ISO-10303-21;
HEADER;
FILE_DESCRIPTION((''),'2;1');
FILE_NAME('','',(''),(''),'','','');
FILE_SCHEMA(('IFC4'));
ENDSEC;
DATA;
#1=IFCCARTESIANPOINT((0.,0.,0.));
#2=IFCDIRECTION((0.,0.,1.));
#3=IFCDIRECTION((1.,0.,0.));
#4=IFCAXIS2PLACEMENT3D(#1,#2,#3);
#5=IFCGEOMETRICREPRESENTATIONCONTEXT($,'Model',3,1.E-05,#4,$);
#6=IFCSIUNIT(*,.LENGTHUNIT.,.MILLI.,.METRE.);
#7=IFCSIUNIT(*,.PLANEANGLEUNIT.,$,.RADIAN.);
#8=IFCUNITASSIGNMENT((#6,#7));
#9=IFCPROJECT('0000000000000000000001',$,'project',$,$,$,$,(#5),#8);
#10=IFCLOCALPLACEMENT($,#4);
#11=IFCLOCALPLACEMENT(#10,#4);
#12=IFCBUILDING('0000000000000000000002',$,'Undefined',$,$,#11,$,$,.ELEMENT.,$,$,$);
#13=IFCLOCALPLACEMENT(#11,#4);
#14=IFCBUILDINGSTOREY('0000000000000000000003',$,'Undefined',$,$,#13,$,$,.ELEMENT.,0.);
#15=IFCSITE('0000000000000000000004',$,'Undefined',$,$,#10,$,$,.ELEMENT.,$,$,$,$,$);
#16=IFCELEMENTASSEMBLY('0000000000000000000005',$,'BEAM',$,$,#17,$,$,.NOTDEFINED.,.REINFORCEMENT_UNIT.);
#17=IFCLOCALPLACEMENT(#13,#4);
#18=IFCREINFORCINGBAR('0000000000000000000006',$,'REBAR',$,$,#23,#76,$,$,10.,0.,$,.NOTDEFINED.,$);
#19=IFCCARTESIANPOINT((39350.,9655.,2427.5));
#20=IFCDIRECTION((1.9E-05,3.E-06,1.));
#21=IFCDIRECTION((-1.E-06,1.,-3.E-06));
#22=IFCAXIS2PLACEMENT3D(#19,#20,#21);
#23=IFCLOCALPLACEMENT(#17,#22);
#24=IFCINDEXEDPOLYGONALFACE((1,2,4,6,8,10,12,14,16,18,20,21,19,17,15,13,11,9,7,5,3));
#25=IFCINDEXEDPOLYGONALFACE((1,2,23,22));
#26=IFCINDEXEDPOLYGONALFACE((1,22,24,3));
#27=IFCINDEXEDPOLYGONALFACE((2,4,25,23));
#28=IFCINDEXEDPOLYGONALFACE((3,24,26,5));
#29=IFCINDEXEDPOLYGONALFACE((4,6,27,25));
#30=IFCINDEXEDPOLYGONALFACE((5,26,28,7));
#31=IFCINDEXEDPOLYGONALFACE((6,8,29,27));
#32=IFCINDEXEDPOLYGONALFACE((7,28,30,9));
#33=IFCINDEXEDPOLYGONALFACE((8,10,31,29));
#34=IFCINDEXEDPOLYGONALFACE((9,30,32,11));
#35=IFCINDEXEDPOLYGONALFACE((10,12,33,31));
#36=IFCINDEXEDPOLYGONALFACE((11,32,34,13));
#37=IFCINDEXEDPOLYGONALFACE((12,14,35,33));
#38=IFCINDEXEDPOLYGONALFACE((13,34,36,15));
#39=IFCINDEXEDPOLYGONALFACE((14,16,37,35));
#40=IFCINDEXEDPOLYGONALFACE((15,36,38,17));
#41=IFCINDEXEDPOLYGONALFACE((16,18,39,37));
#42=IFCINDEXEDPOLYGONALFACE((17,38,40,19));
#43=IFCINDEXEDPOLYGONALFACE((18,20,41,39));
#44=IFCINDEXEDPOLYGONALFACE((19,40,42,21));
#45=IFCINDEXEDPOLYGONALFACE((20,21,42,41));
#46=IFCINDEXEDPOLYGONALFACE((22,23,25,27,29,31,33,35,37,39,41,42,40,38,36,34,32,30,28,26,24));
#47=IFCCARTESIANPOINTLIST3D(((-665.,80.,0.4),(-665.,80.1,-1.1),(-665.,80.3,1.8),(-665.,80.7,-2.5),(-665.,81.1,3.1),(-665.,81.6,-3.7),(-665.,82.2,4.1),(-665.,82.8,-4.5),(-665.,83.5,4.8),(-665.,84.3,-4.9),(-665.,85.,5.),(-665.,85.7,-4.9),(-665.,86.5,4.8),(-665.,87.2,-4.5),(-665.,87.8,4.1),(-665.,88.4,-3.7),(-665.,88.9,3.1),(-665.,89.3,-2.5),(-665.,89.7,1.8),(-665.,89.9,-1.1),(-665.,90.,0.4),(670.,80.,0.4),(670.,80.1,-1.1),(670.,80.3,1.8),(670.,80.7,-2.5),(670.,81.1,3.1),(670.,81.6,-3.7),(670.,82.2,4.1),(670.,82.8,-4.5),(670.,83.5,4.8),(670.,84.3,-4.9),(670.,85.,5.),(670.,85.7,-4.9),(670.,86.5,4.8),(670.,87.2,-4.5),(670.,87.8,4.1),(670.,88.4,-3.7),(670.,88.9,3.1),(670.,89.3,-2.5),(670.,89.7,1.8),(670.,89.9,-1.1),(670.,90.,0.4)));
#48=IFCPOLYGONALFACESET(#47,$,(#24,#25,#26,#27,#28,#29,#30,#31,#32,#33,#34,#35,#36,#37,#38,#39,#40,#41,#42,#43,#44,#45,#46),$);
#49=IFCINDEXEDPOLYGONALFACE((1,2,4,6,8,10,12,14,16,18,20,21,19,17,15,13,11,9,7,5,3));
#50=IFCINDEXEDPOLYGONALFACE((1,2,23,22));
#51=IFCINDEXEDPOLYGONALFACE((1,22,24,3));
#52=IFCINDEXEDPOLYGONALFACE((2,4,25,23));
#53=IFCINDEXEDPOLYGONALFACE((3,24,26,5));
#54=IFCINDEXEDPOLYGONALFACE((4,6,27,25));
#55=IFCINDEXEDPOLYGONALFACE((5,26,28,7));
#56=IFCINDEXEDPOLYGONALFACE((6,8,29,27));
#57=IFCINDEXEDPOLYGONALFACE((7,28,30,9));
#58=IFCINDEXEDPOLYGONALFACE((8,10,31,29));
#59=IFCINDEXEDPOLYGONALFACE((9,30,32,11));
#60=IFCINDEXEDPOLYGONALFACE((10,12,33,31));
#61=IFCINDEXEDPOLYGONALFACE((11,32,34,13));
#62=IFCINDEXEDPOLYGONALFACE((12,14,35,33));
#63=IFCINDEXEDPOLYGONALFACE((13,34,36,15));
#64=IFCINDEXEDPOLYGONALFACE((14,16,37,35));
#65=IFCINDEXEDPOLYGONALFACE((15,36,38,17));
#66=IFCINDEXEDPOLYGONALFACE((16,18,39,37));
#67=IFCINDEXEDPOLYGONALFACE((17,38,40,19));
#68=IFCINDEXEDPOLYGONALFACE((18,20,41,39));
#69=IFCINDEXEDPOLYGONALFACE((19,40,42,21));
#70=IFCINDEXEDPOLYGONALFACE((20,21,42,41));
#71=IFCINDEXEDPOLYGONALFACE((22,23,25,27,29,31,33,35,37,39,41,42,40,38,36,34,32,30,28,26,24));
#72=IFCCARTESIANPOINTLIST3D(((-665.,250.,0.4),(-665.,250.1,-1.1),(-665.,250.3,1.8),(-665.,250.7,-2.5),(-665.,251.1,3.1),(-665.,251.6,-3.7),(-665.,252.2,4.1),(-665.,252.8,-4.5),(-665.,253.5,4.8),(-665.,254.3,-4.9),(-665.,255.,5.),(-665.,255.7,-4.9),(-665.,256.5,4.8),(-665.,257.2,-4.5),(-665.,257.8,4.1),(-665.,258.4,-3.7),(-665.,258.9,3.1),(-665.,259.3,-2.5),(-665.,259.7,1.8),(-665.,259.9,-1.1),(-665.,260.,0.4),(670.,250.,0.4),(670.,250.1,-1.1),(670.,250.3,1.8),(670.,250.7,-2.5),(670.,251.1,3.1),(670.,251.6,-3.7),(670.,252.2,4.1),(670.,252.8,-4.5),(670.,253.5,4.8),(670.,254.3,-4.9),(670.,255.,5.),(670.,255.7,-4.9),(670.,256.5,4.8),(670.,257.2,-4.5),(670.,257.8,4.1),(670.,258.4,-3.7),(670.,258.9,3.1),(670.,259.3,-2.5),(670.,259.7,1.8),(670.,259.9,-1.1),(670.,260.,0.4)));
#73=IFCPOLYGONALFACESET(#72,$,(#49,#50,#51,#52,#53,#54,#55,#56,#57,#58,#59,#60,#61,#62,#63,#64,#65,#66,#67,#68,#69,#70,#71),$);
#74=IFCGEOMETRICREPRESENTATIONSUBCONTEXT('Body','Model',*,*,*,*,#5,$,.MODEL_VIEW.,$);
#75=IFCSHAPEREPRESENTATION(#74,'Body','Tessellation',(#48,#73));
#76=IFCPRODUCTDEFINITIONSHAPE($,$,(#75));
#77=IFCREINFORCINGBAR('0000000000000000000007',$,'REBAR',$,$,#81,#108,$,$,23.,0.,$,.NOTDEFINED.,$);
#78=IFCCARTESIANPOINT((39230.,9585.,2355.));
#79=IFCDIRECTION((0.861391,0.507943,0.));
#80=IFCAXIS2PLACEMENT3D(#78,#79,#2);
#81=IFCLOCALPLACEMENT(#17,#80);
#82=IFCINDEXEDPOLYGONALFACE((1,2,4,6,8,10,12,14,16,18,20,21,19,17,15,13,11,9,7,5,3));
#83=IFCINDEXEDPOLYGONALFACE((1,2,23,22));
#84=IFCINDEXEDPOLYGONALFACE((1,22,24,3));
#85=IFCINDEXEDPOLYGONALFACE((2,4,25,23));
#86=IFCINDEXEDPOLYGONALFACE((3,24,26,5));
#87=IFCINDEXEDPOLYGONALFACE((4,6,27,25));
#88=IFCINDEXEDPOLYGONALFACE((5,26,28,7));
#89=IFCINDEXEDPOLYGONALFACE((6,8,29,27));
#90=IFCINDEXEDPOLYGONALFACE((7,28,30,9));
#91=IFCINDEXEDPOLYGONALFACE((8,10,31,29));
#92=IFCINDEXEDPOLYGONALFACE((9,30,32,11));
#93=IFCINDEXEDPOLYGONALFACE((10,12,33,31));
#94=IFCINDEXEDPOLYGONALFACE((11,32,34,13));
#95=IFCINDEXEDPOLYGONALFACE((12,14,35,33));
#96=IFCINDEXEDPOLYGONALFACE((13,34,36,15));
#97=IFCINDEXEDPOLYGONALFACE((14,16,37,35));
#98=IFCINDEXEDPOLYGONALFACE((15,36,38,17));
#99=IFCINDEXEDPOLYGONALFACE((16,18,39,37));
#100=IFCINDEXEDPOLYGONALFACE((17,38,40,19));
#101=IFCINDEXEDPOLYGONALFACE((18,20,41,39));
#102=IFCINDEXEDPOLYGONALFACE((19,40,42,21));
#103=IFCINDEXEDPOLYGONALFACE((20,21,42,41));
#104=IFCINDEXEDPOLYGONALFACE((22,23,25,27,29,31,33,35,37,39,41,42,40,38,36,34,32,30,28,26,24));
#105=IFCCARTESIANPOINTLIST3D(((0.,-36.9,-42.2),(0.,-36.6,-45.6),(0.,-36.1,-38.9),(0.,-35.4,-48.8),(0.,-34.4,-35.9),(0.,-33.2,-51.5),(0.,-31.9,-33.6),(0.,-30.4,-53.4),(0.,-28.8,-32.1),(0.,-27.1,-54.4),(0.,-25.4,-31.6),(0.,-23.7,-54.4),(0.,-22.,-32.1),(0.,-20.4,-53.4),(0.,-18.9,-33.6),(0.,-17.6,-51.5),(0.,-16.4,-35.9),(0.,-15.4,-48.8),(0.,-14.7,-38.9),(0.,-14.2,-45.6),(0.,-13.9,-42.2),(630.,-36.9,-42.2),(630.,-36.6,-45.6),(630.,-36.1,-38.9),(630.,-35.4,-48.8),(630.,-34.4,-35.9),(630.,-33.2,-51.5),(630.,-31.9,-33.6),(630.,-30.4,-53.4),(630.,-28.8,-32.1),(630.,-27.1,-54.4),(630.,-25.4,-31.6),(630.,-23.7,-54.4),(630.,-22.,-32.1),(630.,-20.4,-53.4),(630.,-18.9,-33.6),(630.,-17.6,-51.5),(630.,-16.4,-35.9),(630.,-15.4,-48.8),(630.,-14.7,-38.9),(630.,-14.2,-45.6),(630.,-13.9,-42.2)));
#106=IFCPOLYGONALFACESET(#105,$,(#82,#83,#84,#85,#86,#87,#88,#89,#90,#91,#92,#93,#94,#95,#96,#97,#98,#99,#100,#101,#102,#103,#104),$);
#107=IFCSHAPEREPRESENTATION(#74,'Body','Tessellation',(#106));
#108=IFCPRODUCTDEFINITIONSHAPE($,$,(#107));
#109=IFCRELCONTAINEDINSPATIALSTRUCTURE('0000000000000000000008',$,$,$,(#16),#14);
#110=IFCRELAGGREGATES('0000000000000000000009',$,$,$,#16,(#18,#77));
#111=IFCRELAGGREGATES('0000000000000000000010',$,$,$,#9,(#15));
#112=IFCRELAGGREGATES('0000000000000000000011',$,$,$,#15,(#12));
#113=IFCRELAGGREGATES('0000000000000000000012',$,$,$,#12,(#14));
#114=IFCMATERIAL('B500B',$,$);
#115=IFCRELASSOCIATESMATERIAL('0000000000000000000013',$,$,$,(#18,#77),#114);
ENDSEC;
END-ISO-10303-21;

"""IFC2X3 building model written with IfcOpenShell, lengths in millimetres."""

from ifc_helpers import new_model, entity, si_unit, frame, origin_with_axes, place, context, subcontext, project, spatial, source, transform, mapped, material, element, aggregate, save


model = new_model("IFC2X3")

# Units and contexts
model_context = context("Model", 3, precision=1e-05, world=origin_with_axes())
body_context = subcontext(model_context, "Body", "Model", "MODEL_VIEW")
ifc_project = project(units=[si_unit("LENGTHUNIT", "METRE", prefix="MILLI"), si_unit("PLANEANGLEUNIT", "RADIAN")], contexts=[model_context])

# Site, building, storey
site_placement = place(None, origin_with_axes())
site = spatial("IfcSite", under=ifc_project, at=site_placement, Name="Undefined", CompositionType="ELEMENT")
building_placement = place(site_placement, origin_with_axes())
building = spatial("IfcBuilding", under=site, at=building_placement, Name="Undefined", CompositionType="ELEMENT")
storey_placement = place(building_placement, origin_with_axes())
storey = spatial("IfcBuildingStorey", under=building, at=storey_placement, Name="Undefined", CompositionType="ELEMENT", Elevation=0.0)

# Shared definitions
ifc_material_1 = material(Name="B500B")

# Element assembly, reinforcing bars
assembly_1_placement = place(storey_placement, origin_with_axes())
assembly_1 = element("IfcElementAssembly", 1, at=assembly_1_placement, inside=storey, Name="BEAM", AssemblyPlace="NOTDEFINED", PredefinedType="REINFORCEMENT_UNIT")
shared_shape_1 = source(origin_with_axes(), body_context, "Body", "AdvancedSweptSolid", [
    entity("IfcSweptDiskSolid", entity("IfcTrimmedCurve", entity("IfcLine", entity("IfcCartesianPoint", [0.0, 0.0, 0.0]), entity("IfcVector", entity("IfcDirection", [1.0, 0.0, 0.0]), 1.0)), [entity("IfcParameterValue", 0.0)], [entity("IfcParameterValue", 1335.009613)], True, "PARAMETER"), 5.0, None, 0.0, 1335.0),
])
shared_shape_2 = source(origin_with_axes(), body_context, "Body", "AdvancedSweptSolid", [
    entity("IfcSweptDiskSolid", entity("IfcTrimmedCurve", entity("IfcLine", entity("IfcCartesianPoint", [0.0, 0.0, 0.0]), entity("IfcVector", entity("IfcDirection", [1.0, 0.0, 0.0]), 1.0)), [entity("IfcParameterValue", 0.0)], [entity("IfcParameterValue", 1335.009613)], True, "PARAMETER"), 5.0, None, 0.0, 1335.0),
])
reinforcing_bar_1_placement = place(assembly_1_placement, frame((39350.0, 9655.0, 2427.5), z_axis=(0.000019, 0.000003, 1.0), x_axis=(-0.000001, 1.0, -0.000003)))
reinforcing_bar_1 = element("IfcReinforcingBar", 2, at=reinforcing_bar_1_placement, material=ifc_material_1, Name="REBAR", BarRole="NOTDEFINED", CrossSectionArea=0.0, NominalDiameter=10.0, context=body_context, shape_type="MappedRepresentation", body=[
    mapped(shared_shape_1, transform((-665.0, 85.0, 0.0))),
    mapped(shared_shape_2, transform((-665.0, 255.0, 0.0))),
])
shared_shape_3 = source(origin_with_axes(), body_context, "Body", "AdvancedSweptSolid", [
    entity("IfcSweptDiskSolid", entity("IfcTrimmedCurve", entity("IfcLine", entity("IfcCartesianPoint", [0.0, 0.0, 0.0]), entity("IfcVector", entity("IfcDirection", [1.0, 0.0, 0.0]), 1.0)), [entity("IfcParameterValue", 0.0)], [entity("IfcParameterValue", 630.0)], True, "PARAMETER"), 11.5, None, 0.0, 630.0),
])
reinforcing_bar_2_placement = place(assembly_1_placement, frame((39230.0, 9585.0, 2355.0), z_axis=(0.861391, 0.507943, 0.0), x_axis=(0.0, 0.0, 1.0)))
reinforcing_bar_2 = element("IfcReinforcingBar", 3, at=reinforcing_bar_2_placement, material=ifc_material_1, Name="REBAR", BarRole="NOTDEFINED", CrossSectionArea=0.0, NominalDiameter=23.0, context=body_context, shape_type="MappedRepresentation", body=[
    mapped(shared_shape_3, transform((0.0, -25.4, -43.1))),
])
aggregate(assembly_1, [reinforcing_bar_1, reinforcing_bar_2])

save(model, "model.ifc")
